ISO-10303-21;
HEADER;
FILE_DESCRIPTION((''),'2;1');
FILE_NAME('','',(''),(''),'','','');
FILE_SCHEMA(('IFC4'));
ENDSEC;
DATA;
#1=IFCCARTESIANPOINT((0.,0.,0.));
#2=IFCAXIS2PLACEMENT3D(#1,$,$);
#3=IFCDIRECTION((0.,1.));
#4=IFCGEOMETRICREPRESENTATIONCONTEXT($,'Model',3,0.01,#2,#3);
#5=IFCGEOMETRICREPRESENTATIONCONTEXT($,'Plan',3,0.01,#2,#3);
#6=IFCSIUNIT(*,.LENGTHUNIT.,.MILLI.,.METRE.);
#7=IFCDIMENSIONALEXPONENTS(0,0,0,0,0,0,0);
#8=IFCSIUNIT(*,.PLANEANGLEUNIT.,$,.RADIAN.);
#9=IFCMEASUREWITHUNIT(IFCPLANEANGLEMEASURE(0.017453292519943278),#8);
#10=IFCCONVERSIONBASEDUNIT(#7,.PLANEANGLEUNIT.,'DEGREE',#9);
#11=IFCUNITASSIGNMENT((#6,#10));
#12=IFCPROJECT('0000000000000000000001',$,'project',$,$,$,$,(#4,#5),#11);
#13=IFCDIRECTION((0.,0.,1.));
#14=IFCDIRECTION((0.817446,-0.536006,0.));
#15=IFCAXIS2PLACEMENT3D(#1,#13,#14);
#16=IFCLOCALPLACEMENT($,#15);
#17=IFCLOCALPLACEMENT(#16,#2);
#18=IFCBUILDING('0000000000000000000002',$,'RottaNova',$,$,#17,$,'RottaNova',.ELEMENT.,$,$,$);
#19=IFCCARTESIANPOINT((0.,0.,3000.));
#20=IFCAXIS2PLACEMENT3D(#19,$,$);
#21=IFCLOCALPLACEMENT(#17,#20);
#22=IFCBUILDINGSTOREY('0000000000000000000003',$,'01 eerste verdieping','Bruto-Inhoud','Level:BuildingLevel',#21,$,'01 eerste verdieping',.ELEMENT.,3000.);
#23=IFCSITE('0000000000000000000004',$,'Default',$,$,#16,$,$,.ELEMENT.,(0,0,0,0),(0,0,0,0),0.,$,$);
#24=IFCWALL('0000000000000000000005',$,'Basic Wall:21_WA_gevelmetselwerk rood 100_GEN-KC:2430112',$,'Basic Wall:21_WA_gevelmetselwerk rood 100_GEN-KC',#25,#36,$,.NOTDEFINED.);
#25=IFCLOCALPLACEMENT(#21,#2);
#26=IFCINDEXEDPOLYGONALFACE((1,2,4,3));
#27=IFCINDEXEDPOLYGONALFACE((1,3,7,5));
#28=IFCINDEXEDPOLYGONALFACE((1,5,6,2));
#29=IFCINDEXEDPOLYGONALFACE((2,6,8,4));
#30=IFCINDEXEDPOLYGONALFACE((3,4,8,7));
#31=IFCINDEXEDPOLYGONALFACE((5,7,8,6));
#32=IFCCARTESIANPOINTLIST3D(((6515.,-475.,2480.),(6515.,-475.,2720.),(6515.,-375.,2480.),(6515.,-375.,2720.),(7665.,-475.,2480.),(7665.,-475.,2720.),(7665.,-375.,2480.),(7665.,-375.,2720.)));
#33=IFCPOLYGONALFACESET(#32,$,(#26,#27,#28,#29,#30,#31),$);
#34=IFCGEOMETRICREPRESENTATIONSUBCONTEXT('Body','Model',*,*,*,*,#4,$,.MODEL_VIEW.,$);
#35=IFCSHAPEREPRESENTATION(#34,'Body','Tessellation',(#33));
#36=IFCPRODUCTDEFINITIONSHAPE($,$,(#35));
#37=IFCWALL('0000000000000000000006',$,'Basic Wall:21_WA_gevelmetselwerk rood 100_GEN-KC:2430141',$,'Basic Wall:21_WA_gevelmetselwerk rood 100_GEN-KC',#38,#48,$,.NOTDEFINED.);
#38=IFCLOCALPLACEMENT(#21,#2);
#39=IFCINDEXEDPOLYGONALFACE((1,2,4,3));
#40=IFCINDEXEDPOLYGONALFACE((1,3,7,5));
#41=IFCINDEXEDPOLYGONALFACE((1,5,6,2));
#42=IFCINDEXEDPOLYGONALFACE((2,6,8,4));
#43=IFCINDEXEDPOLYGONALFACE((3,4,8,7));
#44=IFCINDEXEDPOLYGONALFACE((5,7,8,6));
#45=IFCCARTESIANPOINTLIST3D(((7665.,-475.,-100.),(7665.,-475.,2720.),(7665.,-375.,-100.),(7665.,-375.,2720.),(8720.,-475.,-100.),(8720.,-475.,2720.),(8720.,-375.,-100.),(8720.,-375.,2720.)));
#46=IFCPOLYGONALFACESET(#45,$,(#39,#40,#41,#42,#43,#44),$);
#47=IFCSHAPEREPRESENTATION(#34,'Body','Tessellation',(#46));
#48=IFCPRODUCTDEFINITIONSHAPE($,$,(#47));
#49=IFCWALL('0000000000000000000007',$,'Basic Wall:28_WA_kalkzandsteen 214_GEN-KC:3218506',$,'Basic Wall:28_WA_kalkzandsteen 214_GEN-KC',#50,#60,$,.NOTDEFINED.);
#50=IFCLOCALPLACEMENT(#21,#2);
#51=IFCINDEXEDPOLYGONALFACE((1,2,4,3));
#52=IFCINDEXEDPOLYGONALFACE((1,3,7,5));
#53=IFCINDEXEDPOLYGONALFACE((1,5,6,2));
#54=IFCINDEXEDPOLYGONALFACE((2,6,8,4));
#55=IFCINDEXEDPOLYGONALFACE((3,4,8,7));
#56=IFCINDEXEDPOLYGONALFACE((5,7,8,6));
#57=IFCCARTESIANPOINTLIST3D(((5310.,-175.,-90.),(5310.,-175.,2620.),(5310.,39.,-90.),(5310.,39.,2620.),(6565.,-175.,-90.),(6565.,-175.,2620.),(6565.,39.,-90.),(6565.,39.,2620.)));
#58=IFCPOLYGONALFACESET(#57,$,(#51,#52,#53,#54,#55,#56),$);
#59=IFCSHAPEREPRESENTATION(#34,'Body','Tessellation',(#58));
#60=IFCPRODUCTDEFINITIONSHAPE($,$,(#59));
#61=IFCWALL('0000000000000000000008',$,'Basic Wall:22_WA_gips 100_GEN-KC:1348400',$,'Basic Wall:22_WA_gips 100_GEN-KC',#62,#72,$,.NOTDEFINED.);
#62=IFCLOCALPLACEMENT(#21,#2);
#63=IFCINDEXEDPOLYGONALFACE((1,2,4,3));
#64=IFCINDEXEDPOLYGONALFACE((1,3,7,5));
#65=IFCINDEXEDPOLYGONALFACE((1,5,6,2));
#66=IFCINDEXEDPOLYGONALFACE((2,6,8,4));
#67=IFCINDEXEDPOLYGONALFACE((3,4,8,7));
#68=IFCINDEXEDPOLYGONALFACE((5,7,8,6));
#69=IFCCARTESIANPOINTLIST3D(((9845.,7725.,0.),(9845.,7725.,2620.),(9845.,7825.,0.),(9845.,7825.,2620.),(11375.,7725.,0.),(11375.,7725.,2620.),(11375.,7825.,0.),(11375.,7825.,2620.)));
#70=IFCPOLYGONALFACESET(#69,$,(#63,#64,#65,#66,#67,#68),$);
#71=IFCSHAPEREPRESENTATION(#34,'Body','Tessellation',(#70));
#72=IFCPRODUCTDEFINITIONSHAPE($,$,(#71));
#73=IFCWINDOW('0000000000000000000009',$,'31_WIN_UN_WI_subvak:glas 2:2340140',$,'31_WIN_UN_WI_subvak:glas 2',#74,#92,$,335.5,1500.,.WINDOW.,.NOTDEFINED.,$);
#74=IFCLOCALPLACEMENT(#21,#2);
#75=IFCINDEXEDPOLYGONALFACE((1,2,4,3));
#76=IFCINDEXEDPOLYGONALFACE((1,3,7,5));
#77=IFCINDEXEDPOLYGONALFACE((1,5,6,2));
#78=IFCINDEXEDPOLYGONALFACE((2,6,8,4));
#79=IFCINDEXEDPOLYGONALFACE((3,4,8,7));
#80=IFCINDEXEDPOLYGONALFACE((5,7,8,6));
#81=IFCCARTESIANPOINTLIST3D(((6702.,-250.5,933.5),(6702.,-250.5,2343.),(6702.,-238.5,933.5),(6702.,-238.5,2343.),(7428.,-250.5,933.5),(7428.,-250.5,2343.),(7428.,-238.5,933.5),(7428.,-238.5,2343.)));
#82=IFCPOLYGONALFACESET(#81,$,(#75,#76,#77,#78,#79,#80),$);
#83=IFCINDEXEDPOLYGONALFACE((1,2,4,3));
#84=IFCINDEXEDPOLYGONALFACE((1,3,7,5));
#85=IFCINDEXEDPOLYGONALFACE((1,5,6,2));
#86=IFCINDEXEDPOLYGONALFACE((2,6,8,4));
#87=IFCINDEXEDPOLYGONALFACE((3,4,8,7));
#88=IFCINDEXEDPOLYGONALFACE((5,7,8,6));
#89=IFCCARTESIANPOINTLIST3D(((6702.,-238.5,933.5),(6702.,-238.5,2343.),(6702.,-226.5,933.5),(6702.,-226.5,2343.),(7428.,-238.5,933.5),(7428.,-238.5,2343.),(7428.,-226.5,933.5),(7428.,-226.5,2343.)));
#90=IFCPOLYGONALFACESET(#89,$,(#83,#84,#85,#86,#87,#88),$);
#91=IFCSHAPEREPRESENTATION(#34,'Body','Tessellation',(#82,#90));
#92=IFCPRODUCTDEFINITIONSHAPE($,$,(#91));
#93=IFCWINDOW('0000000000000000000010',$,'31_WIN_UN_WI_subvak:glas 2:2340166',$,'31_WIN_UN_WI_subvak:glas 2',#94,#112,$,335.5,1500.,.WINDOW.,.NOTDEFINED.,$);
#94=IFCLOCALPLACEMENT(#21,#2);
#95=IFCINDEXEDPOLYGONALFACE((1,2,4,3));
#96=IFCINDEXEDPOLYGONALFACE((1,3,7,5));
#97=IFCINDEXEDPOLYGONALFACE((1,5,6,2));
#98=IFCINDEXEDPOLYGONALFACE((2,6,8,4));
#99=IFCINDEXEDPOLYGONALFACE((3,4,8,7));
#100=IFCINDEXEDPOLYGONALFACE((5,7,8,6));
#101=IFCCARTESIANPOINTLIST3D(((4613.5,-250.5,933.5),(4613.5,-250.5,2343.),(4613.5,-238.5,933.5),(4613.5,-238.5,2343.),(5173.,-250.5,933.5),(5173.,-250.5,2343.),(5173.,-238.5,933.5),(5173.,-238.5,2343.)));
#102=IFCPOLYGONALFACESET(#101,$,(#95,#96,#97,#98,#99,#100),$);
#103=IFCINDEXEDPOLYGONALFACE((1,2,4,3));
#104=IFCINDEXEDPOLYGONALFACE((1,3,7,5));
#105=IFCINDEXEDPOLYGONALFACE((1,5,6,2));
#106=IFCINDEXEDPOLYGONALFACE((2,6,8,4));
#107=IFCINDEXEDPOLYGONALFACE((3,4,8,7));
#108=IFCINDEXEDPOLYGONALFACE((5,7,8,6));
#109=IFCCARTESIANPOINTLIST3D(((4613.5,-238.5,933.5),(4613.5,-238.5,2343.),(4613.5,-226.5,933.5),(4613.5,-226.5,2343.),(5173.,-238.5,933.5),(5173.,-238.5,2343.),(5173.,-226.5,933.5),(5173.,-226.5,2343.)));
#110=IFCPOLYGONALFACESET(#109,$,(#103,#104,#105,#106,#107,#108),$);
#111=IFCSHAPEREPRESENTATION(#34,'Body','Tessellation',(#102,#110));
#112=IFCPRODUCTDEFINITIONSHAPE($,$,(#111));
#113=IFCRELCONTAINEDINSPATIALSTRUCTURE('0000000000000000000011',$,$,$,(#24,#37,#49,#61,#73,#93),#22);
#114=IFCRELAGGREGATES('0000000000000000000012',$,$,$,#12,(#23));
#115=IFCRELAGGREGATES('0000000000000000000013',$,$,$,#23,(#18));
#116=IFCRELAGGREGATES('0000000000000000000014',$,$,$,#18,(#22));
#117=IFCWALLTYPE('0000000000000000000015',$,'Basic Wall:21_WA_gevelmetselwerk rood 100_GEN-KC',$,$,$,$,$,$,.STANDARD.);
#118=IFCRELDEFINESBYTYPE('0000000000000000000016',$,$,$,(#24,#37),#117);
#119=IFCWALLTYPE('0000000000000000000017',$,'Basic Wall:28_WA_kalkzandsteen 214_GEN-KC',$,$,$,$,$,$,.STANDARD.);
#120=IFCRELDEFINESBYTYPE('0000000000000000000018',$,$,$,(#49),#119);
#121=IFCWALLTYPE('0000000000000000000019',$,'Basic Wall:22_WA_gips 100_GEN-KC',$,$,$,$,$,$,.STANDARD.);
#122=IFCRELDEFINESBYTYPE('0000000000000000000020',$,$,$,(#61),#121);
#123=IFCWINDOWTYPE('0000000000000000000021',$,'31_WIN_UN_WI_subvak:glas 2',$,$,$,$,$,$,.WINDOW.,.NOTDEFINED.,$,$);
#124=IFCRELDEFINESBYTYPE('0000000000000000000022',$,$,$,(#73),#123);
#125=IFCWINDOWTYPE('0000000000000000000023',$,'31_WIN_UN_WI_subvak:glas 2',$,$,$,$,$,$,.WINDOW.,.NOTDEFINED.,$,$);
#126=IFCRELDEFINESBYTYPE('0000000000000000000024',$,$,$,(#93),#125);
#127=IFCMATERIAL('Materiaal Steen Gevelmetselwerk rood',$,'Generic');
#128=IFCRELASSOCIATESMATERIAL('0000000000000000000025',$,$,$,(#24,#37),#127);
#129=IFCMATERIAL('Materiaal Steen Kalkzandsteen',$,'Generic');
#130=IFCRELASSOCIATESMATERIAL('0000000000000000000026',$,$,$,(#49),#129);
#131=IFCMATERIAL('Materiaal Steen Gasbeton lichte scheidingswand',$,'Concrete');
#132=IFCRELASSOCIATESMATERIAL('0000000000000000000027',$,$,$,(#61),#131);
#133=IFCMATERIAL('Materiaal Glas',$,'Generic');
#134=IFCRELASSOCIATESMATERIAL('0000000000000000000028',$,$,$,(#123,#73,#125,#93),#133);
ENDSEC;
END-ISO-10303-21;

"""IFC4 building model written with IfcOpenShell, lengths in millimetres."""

from ifc_helpers import new_model, entity, si_unit, converted_unit, direction, frame, origin, place, context, subcontext, project, spatial, indexed_curve, outline, extrude, source, transform, mapped, material, type_object, type_shapes, element, save


model = new_model("IFC4")

# Units and contexts
model_context = context("Model", 3, precision=0.01, world=origin(), true_north=direction((0.0, 1.0)))
plan_context = context("Plan", 3, precision=0.01, world=origin(), true_north=direction((0.0, 1.0)))
body_context = subcontext(model_context, "Body", "Model", "MODEL_VIEW")
ifc_project = project(units=[si_unit("LENGTHUNIT", "METRE", prefix="MILLI"), converted_unit("PLANEANGLEUNIT", "DEGREE", entity("IfcPlaneAngleMeasure", 0.017453292519943278), si_unit("PLANEANGLEUNIT", "RADIAN"), dimensions=[0, 0, 0, 0, 0, 0, 0])], contexts=[model_context, plan_context])

# Site, building, storey
site_placement = place(None, frame((0.0, 0.0, 0.0), z_axis=(0.0, 0.0, 1.0), x_axis=(0.817446, -0.536006, 0.0)))
site = spatial("IfcSite", under=ifc_project, at=site_placement, Name="Default", CompositionType="ELEMENT", RefLatitude=(0, 0, 0, 0), RefLongitude=(0, 0, 0, 0), RefElevation=0.0)
building_placement = place(site_placement, origin())
building = spatial("IfcBuilding", under=site, at=building_placement, Name="RottaNova", LongName="RottaNova", CompositionType="ELEMENT")
storey_placement = place(building_placement, frame((0.0, 0.0, 3000.0)))
storey = spatial("IfcBuildingStorey", under=building, at=storey_placement, Name="01 eerste verdieping", Description="Bruto-Inhoud", ObjectType="Level:BuildingLevel", LongName="01 eerste verdieping", CompositionType="ELEMENT", Elevation=3000.0)

# Shared definitions
ifc_material_1 = material(Name="Materiaal Glas", Category="Generic")

# Walls
ifc_material_2 = material(Name="Materiaal Steen Gevelmetselwerk rood", Category="Generic")
wall_type_1 = type_object("IfcWallType", Name="Basic Wall:21_WA_gevelmetselwerk rood 100_GEN-KC", PredefinedType="STANDARD")
wall_1_placement = place(storey_placement, frame((6515.0, -425.0, 2480.0)))
element("IfcWall", 1, at=wall_1_placement, inside=storey, type_object=wall_type_1, material=ifc_material_2, Name="Basic Wall:21_WA_gevelmetselwerk rood 100_GEN-KC:2430112", ObjectType="Basic Wall:21_WA_gevelmetselwerk rood 100_GEN-KC", PredefinedType="NOTDEFINED", context=body_context, shape_type="SweptSolid", body=[
    extrude(outline(indexed_curve([(1150.0, 50.0), (0.0, 50.0), (0.0, -50.0), (1150.0, -50.0), (1150.0, 50.0)], self_intersect=False)), origin(), (0.0, 0.0, 1.0), 240.0),
])
wall_2_placement = place(storey_placement, frame((7665.0, -425.0, -100.0)))
element("IfcWall", 2, at=wall_2_placement, inside=storey, type_object=wall_type_1, material=ifc_material_2, Name="Basic Wall:21_WA_gevelmetselwerk rood 100_GEN-KC:2430141", ObjectType="Basic Wall:21_WA_gevelmetselwerk rood 100_GEN-KC", PredefinedType="NOTDEFINED", context=body_context, shape_type="SweptSolid", body=[
    extrude(outline(indexed_curve([(1055.0, 50.0), (0.0, 50.0), (0.0, -50.0), (1055.0, -50.0), (1055.0, 50.0)], self_intersect=False)), origin(), (0.0, 0.0, 1.0), 2820.0),
])
ifc_material_3 = material(Name="Materiaal Steen Kalkzandsteen", Category="Generic")
wall_type_2 = type_object("IfcWallType", Name="Basic Wall:28_WA_kalkzandsteen 214_GEN-KC", PredefinedType="STANDARD")
wall_3_placement = place(storey_placement, frame((6565.0, -68.0, -90.0), z_axis=(0.0, 0.0, 1.0), x_axis=(-1.0, 0.0, 0.0)))
element("IfcWall", 3, at=wall_3_placement, inside=storey, type_object=wall_type_2, material=ifc_material_3, Name="Basic Wall:28_WA_kalkzandsteen 214_GEN-KC:3218506", ObjectType="Basic Wall:28_WA_kalkzandsteen 214_GEN-KC", PredefinedType="NOTDEFINED", context=body_context, shape_type="SweptSolid", body=[
    extrude(outline(indexed_curve([(1255.0, 107.0), (0.0, 107.0), (0.0, -107.0), (1255.0, -107.0), (1255.0, 107.0)], self_intersect=False)), origin(), (0.0, 0.0, 1.0), 2710.0),
])
ifc_material_4 = material(Name="Materiaal Steen Gasbeton lichte scheidingswand", Category="Concrete")
wall_type_3 = type_object("IfcWallType", Name="Basic Wall:22_WA_gips 100_GEN-KC", PredefinedType="STANDARD")
wall_4_placement = place(storey_placement, frame((9845.0, 7775.0, 0.0)))
element("IfcWall", 4, at=wall_4_placement, inside=storey, type_object=wall_type_3, material=ifc_material_4, Name="Basic Wall:22_WA_gips 100_GEN-KC:1348400", ObjectType="Basic Wall:22_WA_gips 100_GEN-KC", PredefinedType="NOTDEFINED", context=body_context, shape_type="SweptSolid", body=[
    extrude(outline(indexed_curve([(1530.0, 50.0), (0.0, 50.0), (0.0, -50.0), (1530.0, -50.0), (1530.0, 50.0)], self_intersect=False)), origin(), (0.0, 0.0, 1.0), 2620.0),
])

# Windows
window_type_1 = type_object("IfcWindowType", Name="31_WIN_UN_WI_subvak:glas 2", PartitioningType="NOTDEFINED", PredefinedType="WINDOW", material=ifc_material_1)
shared_shape_1 = source(origin(), body_context, "Body", "SweptSolid", [
    extrude(outline(indexed_curve([(-363.0, -6.0), (363.0, -6.0), (363.0, 6.0), (-363.0, 6.0), (-363.0, -6.0)], self_intersect=False)), frame((0.0, -6.0, 0.0)), (0.0, 0.0, 1.0), 1409.5),
    extrude(outline(indexed_curve([(-363.0, -6.0), (363.0, -6.0), (363.0, 6.0), (-363.0, 6.0), (-363.0, -6.0)], self_intersect=False)), frame((0.0, 6.0, 0.0)), (0.0, 0.0, 1.0), 1409.5),
])
type_shapes(window_type_1, [shared_shape_1])
window_1_placement = place(storey_placement, frame((7065.0, -238.5, 933.5)))
element("IfcWindow", 5, at=window_1_placement, inside=storey, type_object=window_type_1, material=ifc_material_1, Name="31_WIN_UN_WI_subvak:glas 2:2340140", ObjectType="31_WIN_UN_WI_subvak:glas 2", OverallHeight=335.5, OverallWidth=1500.0, PartitioningType="NOTDEFINED", PredefinedType="WINDOW", context=body_context, shape_type="MappedRepresentation", body=[
    mapped(shared_shape_1, transform((0.0, 0.0, 0.0), scale=1.0)),
])
window_type_2 = type_object("IfcWindowType", Name="31_WIN_UN_WI_subvak:glas 2", PartitioningType="NOTDEFINED", PredefinedType="WINDOW", material=ifc_material_1)
shared_shape_2 = source(origin(), body_context, "Body", "SweptSolid", [
    extrude(outline(indexed_curve([(-6.0, -279.8), (6.0, -279.8), (6.0, 279.8), (-6.0, 279.8), (-6.0, -279.8)], self_intersect=False)), frame((0.0, 6.0, 0.0), z_axis=(0.0, 0.0, 1.0), x_axis=(0.0, -1.0, 0.0)), (0.0, 0.0, 1.0), 1409.5),
    extrude(outline(indexed_curve([(-6.0, -279.8), (6.0, -279.8), (6.0, 279.8), (-6.0, 279.8), (-6.0, -279.8)], self_intersect=False)), frame((0.0, -6.0, 0.0), z_axis=(0.0, 0.0, 1.0), x_axis=(0.0, -1.0, 0.0)), (0.0, 0.0, 1.0), 1409.5),
])
type_shapes(window_type_2, [shared_shape_2])
window_2_placement = place(storey_placement, frame((4893.2, -238.5, 933.5), z_axis=(0.0, 0.0, 1.0), x_axis=(-1.0, 0.0, 0.0)))
element("IfcWindow", 6, at=window_2_placement, inside=storey, type_object=window_type_2, material=ifc_material_1, Name="31_WIN_UN_WI_subvak:glas 2:2340166", ObjectType="31_WIN_UN_WI_subvak:glas 2", OverallHeight=335.5, OverallWidth=1500.0, PartitioningType="NOTDEFINED", PredefinedType="WINDOW", context=body_context, shape_type="MappedRepresentation", body=[
    mapped(shared_shape_2, transform((0.0, 0.0, 0.0), scale=1.0)),
])

save(model, "model.ifc")
